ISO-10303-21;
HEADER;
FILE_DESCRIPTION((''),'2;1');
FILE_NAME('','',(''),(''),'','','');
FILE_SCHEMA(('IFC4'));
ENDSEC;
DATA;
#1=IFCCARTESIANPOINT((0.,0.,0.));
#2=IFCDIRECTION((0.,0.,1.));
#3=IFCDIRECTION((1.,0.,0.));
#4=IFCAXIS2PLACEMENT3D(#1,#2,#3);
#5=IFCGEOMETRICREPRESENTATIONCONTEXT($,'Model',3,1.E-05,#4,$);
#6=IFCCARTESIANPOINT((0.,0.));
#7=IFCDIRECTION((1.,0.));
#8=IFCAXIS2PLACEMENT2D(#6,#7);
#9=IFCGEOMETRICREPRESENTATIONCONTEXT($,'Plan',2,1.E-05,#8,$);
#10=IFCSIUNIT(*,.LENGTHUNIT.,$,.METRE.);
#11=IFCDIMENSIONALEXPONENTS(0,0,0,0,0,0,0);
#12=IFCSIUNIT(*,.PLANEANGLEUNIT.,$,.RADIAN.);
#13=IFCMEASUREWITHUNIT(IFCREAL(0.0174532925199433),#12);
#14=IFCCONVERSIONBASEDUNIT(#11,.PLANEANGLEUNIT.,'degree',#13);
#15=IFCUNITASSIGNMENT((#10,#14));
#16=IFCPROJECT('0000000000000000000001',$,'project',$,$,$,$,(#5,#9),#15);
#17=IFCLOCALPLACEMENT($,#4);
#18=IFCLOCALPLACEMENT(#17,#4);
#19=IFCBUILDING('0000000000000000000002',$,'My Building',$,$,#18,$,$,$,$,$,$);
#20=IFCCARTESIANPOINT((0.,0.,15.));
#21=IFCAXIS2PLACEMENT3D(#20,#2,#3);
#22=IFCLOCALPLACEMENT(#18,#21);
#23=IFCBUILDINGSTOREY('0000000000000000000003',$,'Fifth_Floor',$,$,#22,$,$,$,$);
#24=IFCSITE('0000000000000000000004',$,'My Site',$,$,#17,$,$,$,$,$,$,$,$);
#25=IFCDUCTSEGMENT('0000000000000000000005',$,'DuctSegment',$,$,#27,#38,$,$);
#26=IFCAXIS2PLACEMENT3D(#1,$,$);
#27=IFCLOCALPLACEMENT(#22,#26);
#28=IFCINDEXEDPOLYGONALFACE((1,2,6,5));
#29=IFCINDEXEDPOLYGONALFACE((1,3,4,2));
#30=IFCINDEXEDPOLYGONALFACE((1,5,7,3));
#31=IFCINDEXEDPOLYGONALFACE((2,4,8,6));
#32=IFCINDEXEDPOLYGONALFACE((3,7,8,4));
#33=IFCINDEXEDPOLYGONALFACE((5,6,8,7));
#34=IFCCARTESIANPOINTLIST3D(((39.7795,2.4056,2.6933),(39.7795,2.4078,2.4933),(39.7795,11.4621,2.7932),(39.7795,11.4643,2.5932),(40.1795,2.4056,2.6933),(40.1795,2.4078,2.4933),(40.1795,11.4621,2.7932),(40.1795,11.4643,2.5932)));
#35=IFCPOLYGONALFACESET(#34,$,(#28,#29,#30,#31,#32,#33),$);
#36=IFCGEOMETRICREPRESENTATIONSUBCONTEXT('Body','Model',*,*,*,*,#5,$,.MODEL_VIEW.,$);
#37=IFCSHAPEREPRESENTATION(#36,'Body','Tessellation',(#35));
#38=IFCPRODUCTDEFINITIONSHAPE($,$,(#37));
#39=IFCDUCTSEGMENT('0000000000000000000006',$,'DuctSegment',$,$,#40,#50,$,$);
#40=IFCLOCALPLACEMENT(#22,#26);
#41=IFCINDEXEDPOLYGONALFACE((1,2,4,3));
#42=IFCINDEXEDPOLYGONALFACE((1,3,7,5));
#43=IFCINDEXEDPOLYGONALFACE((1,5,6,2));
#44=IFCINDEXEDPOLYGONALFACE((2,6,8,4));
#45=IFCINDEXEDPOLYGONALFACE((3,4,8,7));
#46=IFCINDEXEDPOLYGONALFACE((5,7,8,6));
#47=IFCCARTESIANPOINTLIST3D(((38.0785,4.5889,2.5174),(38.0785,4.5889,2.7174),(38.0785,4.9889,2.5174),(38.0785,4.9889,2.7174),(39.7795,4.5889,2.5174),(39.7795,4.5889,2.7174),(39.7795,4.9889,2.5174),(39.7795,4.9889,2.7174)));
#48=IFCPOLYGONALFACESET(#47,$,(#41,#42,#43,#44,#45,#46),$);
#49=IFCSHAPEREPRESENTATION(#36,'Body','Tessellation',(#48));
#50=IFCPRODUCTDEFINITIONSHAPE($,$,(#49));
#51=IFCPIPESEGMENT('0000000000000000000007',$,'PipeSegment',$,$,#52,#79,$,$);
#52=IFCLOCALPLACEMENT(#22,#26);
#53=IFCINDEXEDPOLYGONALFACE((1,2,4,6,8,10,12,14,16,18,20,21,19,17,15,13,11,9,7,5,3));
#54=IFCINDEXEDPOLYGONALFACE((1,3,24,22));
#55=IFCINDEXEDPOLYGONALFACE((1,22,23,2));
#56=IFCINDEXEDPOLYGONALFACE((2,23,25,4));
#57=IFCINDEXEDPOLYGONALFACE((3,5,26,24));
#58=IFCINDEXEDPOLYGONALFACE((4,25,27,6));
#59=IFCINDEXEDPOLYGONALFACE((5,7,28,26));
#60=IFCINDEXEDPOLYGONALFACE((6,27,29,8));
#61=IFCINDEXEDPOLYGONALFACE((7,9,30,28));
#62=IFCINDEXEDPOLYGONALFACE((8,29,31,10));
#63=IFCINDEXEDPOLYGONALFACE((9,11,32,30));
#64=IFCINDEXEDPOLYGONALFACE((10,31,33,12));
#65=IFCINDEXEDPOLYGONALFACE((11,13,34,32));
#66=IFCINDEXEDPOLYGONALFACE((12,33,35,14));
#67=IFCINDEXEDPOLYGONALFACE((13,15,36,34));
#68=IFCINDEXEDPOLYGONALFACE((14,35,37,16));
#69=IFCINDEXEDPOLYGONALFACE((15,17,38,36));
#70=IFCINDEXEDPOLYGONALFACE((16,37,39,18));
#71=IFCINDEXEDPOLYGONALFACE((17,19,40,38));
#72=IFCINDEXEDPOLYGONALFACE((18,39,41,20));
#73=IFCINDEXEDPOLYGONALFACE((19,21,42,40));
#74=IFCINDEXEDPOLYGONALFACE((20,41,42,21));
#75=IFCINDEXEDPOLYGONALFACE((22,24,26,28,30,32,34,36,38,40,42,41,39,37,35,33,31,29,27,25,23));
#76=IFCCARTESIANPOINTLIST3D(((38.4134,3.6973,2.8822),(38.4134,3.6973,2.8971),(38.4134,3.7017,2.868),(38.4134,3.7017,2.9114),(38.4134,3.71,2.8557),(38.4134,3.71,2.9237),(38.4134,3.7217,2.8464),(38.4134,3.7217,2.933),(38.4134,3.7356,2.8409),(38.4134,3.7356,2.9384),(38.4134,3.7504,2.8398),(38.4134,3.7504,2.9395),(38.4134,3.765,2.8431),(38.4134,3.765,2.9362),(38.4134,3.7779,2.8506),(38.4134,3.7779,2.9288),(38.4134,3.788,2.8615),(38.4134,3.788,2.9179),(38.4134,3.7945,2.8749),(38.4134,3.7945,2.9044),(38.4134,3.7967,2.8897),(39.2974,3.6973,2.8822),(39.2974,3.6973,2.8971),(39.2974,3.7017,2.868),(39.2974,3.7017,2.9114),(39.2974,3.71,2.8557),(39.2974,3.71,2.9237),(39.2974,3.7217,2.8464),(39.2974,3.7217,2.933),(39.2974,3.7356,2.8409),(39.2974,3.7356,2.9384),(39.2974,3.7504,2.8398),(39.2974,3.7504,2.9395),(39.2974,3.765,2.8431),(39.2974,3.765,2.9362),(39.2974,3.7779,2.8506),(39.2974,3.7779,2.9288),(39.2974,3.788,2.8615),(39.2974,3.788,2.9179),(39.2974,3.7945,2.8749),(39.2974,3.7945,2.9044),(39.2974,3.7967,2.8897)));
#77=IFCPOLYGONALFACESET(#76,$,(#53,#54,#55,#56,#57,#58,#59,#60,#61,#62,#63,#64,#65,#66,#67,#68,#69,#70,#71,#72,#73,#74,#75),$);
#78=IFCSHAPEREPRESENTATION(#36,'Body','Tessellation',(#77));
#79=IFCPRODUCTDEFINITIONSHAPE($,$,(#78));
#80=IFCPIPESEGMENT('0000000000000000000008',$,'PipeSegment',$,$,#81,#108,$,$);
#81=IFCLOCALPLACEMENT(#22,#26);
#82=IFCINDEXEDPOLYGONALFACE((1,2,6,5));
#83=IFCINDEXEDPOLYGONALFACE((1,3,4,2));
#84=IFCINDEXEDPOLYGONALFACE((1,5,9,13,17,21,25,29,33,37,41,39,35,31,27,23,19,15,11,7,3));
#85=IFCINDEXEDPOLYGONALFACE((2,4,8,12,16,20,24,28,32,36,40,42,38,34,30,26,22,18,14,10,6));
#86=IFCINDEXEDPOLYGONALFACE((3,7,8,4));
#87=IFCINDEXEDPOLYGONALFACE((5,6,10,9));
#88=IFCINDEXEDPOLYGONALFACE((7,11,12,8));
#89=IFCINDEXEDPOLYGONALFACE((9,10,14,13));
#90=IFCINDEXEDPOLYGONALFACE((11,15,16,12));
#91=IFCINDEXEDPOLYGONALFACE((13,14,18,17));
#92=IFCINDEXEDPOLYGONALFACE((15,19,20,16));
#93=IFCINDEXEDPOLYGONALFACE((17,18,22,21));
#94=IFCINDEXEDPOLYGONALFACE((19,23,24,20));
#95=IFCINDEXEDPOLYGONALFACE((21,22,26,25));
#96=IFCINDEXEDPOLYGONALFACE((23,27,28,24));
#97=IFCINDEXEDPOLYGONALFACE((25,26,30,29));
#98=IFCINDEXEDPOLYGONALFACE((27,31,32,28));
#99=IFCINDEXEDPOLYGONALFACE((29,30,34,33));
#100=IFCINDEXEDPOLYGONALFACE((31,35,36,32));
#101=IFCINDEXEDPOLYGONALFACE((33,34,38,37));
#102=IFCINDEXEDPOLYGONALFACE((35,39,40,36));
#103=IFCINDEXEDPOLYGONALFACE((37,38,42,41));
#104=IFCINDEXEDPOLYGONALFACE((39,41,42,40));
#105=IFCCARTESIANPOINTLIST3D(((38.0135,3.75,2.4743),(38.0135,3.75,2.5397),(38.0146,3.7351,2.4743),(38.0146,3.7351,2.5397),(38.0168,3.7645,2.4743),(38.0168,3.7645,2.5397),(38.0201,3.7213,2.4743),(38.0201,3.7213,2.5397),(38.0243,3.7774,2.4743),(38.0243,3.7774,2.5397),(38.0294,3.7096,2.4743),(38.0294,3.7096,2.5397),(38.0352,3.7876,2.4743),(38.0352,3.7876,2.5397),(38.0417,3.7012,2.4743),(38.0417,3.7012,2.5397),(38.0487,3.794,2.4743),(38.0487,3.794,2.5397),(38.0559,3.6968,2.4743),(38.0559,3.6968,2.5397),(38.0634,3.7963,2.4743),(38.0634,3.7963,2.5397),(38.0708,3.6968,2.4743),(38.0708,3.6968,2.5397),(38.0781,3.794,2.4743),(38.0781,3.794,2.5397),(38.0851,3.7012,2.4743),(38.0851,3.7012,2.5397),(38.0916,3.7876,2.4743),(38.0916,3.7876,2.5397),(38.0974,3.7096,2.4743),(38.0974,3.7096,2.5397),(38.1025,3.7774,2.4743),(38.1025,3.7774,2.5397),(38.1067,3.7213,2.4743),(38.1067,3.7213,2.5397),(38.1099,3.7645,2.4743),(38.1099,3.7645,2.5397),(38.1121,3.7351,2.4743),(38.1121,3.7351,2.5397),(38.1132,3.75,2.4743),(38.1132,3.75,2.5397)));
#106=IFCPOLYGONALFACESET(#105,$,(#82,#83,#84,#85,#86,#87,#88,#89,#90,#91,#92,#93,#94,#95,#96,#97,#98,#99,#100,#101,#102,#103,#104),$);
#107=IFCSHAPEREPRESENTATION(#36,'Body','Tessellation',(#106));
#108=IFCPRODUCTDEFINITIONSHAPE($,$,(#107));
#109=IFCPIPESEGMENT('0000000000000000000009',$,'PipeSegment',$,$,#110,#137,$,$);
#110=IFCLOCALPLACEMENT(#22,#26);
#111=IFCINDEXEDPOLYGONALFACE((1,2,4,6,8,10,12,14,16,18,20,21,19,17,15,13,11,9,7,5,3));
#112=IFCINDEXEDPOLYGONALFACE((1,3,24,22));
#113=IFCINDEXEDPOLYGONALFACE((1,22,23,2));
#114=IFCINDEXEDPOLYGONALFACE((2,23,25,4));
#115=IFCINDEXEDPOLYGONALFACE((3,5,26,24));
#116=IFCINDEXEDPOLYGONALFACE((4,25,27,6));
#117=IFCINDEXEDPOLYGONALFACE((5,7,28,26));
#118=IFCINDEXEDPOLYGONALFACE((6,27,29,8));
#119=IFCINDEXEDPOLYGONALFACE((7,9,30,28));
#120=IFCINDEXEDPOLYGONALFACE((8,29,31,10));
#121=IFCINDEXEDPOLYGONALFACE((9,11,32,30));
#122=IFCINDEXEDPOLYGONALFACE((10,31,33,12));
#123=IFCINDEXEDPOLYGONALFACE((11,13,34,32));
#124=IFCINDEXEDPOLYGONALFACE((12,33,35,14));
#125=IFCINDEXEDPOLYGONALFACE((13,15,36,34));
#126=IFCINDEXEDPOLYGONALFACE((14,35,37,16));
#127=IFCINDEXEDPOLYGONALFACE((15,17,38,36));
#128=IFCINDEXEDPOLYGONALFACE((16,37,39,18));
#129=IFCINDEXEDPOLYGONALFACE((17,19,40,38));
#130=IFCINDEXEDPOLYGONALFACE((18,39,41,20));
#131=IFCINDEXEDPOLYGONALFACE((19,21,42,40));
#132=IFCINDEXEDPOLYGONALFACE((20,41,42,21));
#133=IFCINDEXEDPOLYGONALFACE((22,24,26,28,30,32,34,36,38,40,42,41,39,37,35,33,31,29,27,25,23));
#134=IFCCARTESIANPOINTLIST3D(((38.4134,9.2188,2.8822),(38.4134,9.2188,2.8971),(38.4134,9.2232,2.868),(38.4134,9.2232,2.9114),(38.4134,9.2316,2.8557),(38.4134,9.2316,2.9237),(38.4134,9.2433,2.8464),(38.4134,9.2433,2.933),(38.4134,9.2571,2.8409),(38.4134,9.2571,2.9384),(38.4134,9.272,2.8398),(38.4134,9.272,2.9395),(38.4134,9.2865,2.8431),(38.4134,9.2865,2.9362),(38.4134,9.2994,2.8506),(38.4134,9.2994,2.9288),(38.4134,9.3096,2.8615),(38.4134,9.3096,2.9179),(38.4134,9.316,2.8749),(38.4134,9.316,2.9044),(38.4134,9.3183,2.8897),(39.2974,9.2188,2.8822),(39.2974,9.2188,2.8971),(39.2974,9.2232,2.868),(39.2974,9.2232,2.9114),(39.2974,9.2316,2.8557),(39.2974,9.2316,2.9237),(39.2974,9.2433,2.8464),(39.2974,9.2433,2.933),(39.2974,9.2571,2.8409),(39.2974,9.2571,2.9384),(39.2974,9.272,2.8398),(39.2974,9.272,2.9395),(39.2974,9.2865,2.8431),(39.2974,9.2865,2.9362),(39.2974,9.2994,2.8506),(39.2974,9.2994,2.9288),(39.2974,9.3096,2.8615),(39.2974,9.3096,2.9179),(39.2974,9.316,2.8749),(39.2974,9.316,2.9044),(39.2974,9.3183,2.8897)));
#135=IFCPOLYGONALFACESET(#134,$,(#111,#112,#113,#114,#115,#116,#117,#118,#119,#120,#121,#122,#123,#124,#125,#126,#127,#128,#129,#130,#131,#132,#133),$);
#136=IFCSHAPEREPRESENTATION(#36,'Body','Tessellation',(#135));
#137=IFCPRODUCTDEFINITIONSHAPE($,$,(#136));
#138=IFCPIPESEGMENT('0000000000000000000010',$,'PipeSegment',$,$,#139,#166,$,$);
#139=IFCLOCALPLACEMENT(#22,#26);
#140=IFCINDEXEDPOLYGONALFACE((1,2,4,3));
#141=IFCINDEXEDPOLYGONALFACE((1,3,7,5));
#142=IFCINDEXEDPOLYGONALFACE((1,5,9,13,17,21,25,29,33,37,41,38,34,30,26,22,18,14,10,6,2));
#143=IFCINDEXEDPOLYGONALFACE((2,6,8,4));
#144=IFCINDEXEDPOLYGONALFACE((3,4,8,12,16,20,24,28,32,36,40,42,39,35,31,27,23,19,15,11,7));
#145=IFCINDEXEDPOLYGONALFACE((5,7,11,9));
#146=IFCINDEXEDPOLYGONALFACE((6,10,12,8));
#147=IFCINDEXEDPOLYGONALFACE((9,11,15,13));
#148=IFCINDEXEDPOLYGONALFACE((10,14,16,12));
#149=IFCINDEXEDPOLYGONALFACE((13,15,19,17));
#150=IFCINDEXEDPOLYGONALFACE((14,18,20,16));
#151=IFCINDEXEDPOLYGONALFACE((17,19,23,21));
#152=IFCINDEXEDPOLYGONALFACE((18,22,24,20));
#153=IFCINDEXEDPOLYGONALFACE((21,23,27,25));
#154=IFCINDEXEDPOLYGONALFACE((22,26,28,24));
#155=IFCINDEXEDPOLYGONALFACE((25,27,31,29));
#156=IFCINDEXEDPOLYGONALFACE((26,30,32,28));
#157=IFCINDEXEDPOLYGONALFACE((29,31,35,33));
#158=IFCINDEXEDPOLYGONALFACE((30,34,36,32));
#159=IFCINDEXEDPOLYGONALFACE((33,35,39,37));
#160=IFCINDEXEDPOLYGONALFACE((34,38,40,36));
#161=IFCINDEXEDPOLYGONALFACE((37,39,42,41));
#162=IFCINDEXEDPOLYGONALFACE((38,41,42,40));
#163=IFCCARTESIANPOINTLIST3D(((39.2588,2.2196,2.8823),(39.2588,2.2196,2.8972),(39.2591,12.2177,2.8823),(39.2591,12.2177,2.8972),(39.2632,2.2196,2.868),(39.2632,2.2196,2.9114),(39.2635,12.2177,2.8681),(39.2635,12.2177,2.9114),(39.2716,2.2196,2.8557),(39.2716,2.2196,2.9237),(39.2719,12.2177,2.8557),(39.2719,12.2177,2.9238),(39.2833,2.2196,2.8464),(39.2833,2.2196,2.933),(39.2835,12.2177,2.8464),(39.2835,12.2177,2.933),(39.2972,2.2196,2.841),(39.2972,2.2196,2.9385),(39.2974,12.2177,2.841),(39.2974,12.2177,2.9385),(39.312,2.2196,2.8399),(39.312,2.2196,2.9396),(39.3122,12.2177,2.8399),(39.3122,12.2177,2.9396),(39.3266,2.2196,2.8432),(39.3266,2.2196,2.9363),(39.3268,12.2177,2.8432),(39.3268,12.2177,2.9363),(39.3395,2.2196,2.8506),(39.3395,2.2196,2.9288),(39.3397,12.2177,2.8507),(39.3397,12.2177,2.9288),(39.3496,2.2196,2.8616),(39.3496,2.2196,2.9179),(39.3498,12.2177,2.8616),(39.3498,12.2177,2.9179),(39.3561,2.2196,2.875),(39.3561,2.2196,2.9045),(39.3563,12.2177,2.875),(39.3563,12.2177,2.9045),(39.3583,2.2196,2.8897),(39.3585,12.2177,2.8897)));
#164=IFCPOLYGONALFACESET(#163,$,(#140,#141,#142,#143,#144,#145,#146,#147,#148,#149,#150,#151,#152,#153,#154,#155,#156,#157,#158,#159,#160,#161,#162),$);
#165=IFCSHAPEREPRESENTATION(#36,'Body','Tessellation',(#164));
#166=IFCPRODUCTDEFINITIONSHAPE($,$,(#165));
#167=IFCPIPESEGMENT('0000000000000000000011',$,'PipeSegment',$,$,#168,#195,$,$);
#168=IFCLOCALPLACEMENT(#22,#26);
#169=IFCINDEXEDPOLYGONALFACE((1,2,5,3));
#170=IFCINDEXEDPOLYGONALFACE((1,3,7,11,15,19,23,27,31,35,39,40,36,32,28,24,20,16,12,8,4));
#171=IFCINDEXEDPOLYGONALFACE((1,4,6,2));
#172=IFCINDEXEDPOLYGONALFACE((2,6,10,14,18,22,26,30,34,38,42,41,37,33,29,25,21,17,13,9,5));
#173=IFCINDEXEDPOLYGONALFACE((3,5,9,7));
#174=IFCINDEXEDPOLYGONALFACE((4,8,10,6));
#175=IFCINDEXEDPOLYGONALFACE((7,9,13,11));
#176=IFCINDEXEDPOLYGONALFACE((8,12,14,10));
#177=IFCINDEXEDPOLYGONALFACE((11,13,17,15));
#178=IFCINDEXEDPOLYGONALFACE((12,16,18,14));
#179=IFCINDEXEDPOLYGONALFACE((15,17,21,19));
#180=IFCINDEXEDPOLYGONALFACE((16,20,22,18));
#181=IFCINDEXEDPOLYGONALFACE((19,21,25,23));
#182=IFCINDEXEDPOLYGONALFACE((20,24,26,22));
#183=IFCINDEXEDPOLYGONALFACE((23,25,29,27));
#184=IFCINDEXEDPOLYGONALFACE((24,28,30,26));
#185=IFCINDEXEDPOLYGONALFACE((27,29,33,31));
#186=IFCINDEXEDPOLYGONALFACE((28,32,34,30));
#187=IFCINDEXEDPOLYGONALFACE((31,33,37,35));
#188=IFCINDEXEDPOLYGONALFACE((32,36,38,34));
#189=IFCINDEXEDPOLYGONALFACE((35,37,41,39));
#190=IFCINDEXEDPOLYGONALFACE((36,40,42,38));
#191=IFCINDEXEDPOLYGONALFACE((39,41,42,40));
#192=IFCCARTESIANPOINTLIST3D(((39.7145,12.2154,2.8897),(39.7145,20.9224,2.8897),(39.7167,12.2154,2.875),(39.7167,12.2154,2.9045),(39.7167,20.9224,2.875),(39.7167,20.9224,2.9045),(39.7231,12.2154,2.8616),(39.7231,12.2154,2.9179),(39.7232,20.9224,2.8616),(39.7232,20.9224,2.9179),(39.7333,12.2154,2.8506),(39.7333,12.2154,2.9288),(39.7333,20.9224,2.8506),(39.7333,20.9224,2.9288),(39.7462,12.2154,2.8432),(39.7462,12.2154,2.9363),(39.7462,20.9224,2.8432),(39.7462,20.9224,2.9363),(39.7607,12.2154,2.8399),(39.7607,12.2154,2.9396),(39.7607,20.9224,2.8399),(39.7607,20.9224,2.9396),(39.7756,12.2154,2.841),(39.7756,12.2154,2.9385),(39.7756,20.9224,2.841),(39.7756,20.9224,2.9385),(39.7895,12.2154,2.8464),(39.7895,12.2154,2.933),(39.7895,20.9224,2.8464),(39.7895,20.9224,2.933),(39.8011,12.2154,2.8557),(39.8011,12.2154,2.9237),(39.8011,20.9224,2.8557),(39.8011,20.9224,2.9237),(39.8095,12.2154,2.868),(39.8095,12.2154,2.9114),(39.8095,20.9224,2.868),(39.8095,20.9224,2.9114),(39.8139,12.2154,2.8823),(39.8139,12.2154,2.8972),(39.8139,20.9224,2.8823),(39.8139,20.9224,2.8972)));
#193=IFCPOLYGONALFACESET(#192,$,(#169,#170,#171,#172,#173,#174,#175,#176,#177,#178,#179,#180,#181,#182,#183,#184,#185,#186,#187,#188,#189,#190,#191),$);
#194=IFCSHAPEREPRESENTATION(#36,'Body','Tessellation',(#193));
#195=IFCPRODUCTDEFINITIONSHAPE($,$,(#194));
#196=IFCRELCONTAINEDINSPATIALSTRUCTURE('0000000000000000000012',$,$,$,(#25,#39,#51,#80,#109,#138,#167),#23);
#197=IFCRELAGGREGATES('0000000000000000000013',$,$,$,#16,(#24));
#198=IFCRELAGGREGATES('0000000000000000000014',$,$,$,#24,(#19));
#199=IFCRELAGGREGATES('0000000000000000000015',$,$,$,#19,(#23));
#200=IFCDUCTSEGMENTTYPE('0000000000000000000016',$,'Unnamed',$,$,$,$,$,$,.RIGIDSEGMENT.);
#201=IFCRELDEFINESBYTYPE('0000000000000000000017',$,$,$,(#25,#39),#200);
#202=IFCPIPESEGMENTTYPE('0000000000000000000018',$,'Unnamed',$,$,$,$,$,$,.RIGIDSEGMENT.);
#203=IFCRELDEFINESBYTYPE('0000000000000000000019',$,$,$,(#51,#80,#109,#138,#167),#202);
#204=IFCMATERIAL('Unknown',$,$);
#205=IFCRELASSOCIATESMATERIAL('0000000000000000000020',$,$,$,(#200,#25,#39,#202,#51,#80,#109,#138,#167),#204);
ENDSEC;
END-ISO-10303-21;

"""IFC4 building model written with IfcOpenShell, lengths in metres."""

from ifc_helpers import new_model, entity, si_unit, converted_unit, frame, origin_with_axes, origin_2d_with_axis, place, context, subcontext, project, spatial, rectangle, circle, extrude, material, material_profile, profile_set, profile_usage, type_object, element, save


model = new_model("IFC4")

# Units and contexts
model_context = context("Model", 3, precision=1e-05, world=origin_with_axes())
plan_context = context("Plan", 2, precision=1e-05, world=origin_2d_with_axis())
body_context_1 = subcontext(model_context, "Body", "Model", "MODEL_VIEW")
ifc_project = project(units=[si_unit("LENGTHUNIT", "METRE"), converted_unit("PLANEANGLEUNIT", "degree", entity("IfcReal", 0.0174532925199433), si_unit("PLANEANGLEUNIT", "RADIAN"), dimensions=[0, 0, 0, 0, 0, 0, 0])], contexts=[model_context, plan_context])

# Site, building, storey
site_placement = place(None, origin_with_axes())
site = spatial("IfcSite", under=ifc_project, at=site_placement, Name="My Site")
building_placement = place(site_placement, origin_with_axes())
building = spatial("IfcBuilding", under=site, at=building_placement, Name="My Building")
storey_placement = place(building_placement, frame((0.0, 0.0, 15.0), z_axis=(0.0, 0.0, 1.0), x_axis=(1.0, 0.0, 0.0)))
storey = spatial("IfcBuildingStorey", under=building, at=storey_placement, Name="Fifth_Floor")

# Shared definitions
ifc_material = material(Name="Unknown")

# Duct segments
ifc_material_profile_1 = material_profile(ifc_material, rectangle(XDim=0.4, YDim=0.2))
ifc_profile_set_1 = profile_set([ifc_material_profile_1])
duct_segment_type = type_object("IfcDuctSegmentType", Name="Unnamed", PredefinedType="RIGIDSEGMENT", material=ifc_profile_set_1)
ifc_profile_usage_1 = profile_usage(ifc_profile_set_1, cardinal=5)
duct_segment_1_placement = place(storey_placement, frame((39.9795, 2.4067, 2.5933), z_axis=(0.0, 0.999939, 0.011037), x_axis=(-1.0, 0.0, 0.0)))
element("IfcDuctSegment", 1, at=duct_segment_1_placement, inside=storey, type_object=duct_segment_type, material=ifc_profile_usage_1, Name="DuctSegment", context=body_context_1, shape_type="SweptSolid", body=[
    extrude(rectangle(XDim=0.4, YDim=0.2), origin_with_axes(), (0.0, 0.0, 1.0), 9.057),
])
ifc_profile_usage_2 = profile_usage(ifc_profile_set_1, cardinal=5)
duct_segment_2_placement = place(storey_placement, frame((39.7795, 4.7889, 2.6174), z_axis=(-1.0, 0.000001, 0.000001), x_axis=(-0.000001, -1.0, 0.0)))
element("IfcDuctSegment", 2, at=duct_segment_2_placement, inside=storey, type_object=duct_segment_type, material=ifc_profile_usage_2, Name="DuctSegment", context=body_context_1, shape_type="SweptSolid", body=[
    extrude(rectangle(XDim=0.4, YDim=0.2), origin_with_axes(), (0.0, 0.0, 1.0), 1.701),
])

# Pipe segments
ifc_material_profile_2 = material_profile(ifc_material, circle(Radius=0.05))
ifc_profile_set_2 = profile_set([ifc_material_profile_2])
ifc_profile_usage_3 = profile_usage(ifc_profile_set_2, cardinal=5)
pipe_segment_type = type_object("IfcPipeSegmentType", Name="Unnamed", PredefinedType="RIGIDSEGMENT", material=ifc_profile_set_2)
pipe_segment_1_placement = place(storey_placement, frame((38.4134, 3.7467, 2.8897), z_axis=(1.0, 0.0, 0.0), x_axis=(0.0, 1.0, 0.0)))
element("IfcPipeSegment", 3, at=pipe_segment_1_placement, inside=storey, type_object=pipe_segment_type, material=ifc_profile_usage_3, Name="PipeSegment", context=body_context_1, shape_type="SweptSolid", body=[
    extrude(circle(Radius=0.05), origin_with_axes(), (0.0, 0.0, 1.0), 0.884),
])
ifc_profile_usage_4 = profile_usage(ifc_profile_set_2, cardinal=5)
pipe_segment_2_placement = place(storey_placement, frame((38.0634, 3.7463, 2.4743), z_axis=(0.0, 0.0, 1.0), x_axis=(-0.000001, 1.0, 0.0)))
element("IfcPipeSegment", 4, at=pipe_segment_2_placement, inside=storey, type_object=pipe_segment_type, material=ifc_profile_usage_4, Name="PipeSegment", context=body_context_1, shape_type="SweptSolid", body=[
    extrude(circle(Radius=0.05), origin_with_axes(), (0.0, 0.0, 1.0), 0.0654),
])
ifc_profile_usage_5 = profile_usage(ifc_profile_set_2, cardinal=5)
pipe_segment_3_placement = place(storey_placement, frame((38.4134, 9.2683, 2.8897), z_axis=(1.0, 0.0, 0.0), x_axis=(0.0, 1.0, 0.0)))
element("IfcPipeSegment", 5, at=pipe_segment_3_placement, inside=storey, type_object=pipe_segment_type, material=ifc_profile_usage_5, Name="PipeSegment", context=body_context_1, shape_type="SweptSolid", body=[
    extrude(circle(Radius=0.05), origin_with_axes(), (0.0, 0.0, 1.0), 0.884),
])
ifc_profile_usage_6 = profile_usage(ifc_profile_set_2, cardinal=5)
pipe_segment_4_placement = place(storey_placement, frame((39.3085, 12.2177, 2.8897), z_axis=(-0.000022, -1.0, -0.000003), x_axis=(1.0, -0.000022, 0.0)))
element("IfcPipeSegment", 6, at=pipe_segment_4_placement, inside=storey, type_object=pipe_segment_type, material=ifc_profile_usage_6, Name="PipeSegment", context=body_context_1, shape_type="SweptSolid", body=[
    extrude(circle(Radius=0.05), origin_with_axes(), (0.0, 0.0, 1.0), 9.9981),
])
ifc_profile_usage_7 = profile_usage(ifc_profile_set_2, cardinal=5)
pipe_segment_5_placement = place(storey_placement, frame((39.7645, 12.2154, 2.8897), z_axis=(0.0, 1.0, 0.0), x_axis=(-1.0, 0.0, 0.0)))
element("IfcPipeSegment", 7, at=pipe_segment_5_placement, inside=storey, type_object=pipe_segment_type, material=ifc_profile_usage_7, Name="PipeSegment", context=body_context_1, shape_type="SweptSolid", body=[
    extrude(circle(Radius=0.05), origin_with_axes(), (0.0, 0.0, 1.0), 8.707),
])

save(model, "model.ifc")
